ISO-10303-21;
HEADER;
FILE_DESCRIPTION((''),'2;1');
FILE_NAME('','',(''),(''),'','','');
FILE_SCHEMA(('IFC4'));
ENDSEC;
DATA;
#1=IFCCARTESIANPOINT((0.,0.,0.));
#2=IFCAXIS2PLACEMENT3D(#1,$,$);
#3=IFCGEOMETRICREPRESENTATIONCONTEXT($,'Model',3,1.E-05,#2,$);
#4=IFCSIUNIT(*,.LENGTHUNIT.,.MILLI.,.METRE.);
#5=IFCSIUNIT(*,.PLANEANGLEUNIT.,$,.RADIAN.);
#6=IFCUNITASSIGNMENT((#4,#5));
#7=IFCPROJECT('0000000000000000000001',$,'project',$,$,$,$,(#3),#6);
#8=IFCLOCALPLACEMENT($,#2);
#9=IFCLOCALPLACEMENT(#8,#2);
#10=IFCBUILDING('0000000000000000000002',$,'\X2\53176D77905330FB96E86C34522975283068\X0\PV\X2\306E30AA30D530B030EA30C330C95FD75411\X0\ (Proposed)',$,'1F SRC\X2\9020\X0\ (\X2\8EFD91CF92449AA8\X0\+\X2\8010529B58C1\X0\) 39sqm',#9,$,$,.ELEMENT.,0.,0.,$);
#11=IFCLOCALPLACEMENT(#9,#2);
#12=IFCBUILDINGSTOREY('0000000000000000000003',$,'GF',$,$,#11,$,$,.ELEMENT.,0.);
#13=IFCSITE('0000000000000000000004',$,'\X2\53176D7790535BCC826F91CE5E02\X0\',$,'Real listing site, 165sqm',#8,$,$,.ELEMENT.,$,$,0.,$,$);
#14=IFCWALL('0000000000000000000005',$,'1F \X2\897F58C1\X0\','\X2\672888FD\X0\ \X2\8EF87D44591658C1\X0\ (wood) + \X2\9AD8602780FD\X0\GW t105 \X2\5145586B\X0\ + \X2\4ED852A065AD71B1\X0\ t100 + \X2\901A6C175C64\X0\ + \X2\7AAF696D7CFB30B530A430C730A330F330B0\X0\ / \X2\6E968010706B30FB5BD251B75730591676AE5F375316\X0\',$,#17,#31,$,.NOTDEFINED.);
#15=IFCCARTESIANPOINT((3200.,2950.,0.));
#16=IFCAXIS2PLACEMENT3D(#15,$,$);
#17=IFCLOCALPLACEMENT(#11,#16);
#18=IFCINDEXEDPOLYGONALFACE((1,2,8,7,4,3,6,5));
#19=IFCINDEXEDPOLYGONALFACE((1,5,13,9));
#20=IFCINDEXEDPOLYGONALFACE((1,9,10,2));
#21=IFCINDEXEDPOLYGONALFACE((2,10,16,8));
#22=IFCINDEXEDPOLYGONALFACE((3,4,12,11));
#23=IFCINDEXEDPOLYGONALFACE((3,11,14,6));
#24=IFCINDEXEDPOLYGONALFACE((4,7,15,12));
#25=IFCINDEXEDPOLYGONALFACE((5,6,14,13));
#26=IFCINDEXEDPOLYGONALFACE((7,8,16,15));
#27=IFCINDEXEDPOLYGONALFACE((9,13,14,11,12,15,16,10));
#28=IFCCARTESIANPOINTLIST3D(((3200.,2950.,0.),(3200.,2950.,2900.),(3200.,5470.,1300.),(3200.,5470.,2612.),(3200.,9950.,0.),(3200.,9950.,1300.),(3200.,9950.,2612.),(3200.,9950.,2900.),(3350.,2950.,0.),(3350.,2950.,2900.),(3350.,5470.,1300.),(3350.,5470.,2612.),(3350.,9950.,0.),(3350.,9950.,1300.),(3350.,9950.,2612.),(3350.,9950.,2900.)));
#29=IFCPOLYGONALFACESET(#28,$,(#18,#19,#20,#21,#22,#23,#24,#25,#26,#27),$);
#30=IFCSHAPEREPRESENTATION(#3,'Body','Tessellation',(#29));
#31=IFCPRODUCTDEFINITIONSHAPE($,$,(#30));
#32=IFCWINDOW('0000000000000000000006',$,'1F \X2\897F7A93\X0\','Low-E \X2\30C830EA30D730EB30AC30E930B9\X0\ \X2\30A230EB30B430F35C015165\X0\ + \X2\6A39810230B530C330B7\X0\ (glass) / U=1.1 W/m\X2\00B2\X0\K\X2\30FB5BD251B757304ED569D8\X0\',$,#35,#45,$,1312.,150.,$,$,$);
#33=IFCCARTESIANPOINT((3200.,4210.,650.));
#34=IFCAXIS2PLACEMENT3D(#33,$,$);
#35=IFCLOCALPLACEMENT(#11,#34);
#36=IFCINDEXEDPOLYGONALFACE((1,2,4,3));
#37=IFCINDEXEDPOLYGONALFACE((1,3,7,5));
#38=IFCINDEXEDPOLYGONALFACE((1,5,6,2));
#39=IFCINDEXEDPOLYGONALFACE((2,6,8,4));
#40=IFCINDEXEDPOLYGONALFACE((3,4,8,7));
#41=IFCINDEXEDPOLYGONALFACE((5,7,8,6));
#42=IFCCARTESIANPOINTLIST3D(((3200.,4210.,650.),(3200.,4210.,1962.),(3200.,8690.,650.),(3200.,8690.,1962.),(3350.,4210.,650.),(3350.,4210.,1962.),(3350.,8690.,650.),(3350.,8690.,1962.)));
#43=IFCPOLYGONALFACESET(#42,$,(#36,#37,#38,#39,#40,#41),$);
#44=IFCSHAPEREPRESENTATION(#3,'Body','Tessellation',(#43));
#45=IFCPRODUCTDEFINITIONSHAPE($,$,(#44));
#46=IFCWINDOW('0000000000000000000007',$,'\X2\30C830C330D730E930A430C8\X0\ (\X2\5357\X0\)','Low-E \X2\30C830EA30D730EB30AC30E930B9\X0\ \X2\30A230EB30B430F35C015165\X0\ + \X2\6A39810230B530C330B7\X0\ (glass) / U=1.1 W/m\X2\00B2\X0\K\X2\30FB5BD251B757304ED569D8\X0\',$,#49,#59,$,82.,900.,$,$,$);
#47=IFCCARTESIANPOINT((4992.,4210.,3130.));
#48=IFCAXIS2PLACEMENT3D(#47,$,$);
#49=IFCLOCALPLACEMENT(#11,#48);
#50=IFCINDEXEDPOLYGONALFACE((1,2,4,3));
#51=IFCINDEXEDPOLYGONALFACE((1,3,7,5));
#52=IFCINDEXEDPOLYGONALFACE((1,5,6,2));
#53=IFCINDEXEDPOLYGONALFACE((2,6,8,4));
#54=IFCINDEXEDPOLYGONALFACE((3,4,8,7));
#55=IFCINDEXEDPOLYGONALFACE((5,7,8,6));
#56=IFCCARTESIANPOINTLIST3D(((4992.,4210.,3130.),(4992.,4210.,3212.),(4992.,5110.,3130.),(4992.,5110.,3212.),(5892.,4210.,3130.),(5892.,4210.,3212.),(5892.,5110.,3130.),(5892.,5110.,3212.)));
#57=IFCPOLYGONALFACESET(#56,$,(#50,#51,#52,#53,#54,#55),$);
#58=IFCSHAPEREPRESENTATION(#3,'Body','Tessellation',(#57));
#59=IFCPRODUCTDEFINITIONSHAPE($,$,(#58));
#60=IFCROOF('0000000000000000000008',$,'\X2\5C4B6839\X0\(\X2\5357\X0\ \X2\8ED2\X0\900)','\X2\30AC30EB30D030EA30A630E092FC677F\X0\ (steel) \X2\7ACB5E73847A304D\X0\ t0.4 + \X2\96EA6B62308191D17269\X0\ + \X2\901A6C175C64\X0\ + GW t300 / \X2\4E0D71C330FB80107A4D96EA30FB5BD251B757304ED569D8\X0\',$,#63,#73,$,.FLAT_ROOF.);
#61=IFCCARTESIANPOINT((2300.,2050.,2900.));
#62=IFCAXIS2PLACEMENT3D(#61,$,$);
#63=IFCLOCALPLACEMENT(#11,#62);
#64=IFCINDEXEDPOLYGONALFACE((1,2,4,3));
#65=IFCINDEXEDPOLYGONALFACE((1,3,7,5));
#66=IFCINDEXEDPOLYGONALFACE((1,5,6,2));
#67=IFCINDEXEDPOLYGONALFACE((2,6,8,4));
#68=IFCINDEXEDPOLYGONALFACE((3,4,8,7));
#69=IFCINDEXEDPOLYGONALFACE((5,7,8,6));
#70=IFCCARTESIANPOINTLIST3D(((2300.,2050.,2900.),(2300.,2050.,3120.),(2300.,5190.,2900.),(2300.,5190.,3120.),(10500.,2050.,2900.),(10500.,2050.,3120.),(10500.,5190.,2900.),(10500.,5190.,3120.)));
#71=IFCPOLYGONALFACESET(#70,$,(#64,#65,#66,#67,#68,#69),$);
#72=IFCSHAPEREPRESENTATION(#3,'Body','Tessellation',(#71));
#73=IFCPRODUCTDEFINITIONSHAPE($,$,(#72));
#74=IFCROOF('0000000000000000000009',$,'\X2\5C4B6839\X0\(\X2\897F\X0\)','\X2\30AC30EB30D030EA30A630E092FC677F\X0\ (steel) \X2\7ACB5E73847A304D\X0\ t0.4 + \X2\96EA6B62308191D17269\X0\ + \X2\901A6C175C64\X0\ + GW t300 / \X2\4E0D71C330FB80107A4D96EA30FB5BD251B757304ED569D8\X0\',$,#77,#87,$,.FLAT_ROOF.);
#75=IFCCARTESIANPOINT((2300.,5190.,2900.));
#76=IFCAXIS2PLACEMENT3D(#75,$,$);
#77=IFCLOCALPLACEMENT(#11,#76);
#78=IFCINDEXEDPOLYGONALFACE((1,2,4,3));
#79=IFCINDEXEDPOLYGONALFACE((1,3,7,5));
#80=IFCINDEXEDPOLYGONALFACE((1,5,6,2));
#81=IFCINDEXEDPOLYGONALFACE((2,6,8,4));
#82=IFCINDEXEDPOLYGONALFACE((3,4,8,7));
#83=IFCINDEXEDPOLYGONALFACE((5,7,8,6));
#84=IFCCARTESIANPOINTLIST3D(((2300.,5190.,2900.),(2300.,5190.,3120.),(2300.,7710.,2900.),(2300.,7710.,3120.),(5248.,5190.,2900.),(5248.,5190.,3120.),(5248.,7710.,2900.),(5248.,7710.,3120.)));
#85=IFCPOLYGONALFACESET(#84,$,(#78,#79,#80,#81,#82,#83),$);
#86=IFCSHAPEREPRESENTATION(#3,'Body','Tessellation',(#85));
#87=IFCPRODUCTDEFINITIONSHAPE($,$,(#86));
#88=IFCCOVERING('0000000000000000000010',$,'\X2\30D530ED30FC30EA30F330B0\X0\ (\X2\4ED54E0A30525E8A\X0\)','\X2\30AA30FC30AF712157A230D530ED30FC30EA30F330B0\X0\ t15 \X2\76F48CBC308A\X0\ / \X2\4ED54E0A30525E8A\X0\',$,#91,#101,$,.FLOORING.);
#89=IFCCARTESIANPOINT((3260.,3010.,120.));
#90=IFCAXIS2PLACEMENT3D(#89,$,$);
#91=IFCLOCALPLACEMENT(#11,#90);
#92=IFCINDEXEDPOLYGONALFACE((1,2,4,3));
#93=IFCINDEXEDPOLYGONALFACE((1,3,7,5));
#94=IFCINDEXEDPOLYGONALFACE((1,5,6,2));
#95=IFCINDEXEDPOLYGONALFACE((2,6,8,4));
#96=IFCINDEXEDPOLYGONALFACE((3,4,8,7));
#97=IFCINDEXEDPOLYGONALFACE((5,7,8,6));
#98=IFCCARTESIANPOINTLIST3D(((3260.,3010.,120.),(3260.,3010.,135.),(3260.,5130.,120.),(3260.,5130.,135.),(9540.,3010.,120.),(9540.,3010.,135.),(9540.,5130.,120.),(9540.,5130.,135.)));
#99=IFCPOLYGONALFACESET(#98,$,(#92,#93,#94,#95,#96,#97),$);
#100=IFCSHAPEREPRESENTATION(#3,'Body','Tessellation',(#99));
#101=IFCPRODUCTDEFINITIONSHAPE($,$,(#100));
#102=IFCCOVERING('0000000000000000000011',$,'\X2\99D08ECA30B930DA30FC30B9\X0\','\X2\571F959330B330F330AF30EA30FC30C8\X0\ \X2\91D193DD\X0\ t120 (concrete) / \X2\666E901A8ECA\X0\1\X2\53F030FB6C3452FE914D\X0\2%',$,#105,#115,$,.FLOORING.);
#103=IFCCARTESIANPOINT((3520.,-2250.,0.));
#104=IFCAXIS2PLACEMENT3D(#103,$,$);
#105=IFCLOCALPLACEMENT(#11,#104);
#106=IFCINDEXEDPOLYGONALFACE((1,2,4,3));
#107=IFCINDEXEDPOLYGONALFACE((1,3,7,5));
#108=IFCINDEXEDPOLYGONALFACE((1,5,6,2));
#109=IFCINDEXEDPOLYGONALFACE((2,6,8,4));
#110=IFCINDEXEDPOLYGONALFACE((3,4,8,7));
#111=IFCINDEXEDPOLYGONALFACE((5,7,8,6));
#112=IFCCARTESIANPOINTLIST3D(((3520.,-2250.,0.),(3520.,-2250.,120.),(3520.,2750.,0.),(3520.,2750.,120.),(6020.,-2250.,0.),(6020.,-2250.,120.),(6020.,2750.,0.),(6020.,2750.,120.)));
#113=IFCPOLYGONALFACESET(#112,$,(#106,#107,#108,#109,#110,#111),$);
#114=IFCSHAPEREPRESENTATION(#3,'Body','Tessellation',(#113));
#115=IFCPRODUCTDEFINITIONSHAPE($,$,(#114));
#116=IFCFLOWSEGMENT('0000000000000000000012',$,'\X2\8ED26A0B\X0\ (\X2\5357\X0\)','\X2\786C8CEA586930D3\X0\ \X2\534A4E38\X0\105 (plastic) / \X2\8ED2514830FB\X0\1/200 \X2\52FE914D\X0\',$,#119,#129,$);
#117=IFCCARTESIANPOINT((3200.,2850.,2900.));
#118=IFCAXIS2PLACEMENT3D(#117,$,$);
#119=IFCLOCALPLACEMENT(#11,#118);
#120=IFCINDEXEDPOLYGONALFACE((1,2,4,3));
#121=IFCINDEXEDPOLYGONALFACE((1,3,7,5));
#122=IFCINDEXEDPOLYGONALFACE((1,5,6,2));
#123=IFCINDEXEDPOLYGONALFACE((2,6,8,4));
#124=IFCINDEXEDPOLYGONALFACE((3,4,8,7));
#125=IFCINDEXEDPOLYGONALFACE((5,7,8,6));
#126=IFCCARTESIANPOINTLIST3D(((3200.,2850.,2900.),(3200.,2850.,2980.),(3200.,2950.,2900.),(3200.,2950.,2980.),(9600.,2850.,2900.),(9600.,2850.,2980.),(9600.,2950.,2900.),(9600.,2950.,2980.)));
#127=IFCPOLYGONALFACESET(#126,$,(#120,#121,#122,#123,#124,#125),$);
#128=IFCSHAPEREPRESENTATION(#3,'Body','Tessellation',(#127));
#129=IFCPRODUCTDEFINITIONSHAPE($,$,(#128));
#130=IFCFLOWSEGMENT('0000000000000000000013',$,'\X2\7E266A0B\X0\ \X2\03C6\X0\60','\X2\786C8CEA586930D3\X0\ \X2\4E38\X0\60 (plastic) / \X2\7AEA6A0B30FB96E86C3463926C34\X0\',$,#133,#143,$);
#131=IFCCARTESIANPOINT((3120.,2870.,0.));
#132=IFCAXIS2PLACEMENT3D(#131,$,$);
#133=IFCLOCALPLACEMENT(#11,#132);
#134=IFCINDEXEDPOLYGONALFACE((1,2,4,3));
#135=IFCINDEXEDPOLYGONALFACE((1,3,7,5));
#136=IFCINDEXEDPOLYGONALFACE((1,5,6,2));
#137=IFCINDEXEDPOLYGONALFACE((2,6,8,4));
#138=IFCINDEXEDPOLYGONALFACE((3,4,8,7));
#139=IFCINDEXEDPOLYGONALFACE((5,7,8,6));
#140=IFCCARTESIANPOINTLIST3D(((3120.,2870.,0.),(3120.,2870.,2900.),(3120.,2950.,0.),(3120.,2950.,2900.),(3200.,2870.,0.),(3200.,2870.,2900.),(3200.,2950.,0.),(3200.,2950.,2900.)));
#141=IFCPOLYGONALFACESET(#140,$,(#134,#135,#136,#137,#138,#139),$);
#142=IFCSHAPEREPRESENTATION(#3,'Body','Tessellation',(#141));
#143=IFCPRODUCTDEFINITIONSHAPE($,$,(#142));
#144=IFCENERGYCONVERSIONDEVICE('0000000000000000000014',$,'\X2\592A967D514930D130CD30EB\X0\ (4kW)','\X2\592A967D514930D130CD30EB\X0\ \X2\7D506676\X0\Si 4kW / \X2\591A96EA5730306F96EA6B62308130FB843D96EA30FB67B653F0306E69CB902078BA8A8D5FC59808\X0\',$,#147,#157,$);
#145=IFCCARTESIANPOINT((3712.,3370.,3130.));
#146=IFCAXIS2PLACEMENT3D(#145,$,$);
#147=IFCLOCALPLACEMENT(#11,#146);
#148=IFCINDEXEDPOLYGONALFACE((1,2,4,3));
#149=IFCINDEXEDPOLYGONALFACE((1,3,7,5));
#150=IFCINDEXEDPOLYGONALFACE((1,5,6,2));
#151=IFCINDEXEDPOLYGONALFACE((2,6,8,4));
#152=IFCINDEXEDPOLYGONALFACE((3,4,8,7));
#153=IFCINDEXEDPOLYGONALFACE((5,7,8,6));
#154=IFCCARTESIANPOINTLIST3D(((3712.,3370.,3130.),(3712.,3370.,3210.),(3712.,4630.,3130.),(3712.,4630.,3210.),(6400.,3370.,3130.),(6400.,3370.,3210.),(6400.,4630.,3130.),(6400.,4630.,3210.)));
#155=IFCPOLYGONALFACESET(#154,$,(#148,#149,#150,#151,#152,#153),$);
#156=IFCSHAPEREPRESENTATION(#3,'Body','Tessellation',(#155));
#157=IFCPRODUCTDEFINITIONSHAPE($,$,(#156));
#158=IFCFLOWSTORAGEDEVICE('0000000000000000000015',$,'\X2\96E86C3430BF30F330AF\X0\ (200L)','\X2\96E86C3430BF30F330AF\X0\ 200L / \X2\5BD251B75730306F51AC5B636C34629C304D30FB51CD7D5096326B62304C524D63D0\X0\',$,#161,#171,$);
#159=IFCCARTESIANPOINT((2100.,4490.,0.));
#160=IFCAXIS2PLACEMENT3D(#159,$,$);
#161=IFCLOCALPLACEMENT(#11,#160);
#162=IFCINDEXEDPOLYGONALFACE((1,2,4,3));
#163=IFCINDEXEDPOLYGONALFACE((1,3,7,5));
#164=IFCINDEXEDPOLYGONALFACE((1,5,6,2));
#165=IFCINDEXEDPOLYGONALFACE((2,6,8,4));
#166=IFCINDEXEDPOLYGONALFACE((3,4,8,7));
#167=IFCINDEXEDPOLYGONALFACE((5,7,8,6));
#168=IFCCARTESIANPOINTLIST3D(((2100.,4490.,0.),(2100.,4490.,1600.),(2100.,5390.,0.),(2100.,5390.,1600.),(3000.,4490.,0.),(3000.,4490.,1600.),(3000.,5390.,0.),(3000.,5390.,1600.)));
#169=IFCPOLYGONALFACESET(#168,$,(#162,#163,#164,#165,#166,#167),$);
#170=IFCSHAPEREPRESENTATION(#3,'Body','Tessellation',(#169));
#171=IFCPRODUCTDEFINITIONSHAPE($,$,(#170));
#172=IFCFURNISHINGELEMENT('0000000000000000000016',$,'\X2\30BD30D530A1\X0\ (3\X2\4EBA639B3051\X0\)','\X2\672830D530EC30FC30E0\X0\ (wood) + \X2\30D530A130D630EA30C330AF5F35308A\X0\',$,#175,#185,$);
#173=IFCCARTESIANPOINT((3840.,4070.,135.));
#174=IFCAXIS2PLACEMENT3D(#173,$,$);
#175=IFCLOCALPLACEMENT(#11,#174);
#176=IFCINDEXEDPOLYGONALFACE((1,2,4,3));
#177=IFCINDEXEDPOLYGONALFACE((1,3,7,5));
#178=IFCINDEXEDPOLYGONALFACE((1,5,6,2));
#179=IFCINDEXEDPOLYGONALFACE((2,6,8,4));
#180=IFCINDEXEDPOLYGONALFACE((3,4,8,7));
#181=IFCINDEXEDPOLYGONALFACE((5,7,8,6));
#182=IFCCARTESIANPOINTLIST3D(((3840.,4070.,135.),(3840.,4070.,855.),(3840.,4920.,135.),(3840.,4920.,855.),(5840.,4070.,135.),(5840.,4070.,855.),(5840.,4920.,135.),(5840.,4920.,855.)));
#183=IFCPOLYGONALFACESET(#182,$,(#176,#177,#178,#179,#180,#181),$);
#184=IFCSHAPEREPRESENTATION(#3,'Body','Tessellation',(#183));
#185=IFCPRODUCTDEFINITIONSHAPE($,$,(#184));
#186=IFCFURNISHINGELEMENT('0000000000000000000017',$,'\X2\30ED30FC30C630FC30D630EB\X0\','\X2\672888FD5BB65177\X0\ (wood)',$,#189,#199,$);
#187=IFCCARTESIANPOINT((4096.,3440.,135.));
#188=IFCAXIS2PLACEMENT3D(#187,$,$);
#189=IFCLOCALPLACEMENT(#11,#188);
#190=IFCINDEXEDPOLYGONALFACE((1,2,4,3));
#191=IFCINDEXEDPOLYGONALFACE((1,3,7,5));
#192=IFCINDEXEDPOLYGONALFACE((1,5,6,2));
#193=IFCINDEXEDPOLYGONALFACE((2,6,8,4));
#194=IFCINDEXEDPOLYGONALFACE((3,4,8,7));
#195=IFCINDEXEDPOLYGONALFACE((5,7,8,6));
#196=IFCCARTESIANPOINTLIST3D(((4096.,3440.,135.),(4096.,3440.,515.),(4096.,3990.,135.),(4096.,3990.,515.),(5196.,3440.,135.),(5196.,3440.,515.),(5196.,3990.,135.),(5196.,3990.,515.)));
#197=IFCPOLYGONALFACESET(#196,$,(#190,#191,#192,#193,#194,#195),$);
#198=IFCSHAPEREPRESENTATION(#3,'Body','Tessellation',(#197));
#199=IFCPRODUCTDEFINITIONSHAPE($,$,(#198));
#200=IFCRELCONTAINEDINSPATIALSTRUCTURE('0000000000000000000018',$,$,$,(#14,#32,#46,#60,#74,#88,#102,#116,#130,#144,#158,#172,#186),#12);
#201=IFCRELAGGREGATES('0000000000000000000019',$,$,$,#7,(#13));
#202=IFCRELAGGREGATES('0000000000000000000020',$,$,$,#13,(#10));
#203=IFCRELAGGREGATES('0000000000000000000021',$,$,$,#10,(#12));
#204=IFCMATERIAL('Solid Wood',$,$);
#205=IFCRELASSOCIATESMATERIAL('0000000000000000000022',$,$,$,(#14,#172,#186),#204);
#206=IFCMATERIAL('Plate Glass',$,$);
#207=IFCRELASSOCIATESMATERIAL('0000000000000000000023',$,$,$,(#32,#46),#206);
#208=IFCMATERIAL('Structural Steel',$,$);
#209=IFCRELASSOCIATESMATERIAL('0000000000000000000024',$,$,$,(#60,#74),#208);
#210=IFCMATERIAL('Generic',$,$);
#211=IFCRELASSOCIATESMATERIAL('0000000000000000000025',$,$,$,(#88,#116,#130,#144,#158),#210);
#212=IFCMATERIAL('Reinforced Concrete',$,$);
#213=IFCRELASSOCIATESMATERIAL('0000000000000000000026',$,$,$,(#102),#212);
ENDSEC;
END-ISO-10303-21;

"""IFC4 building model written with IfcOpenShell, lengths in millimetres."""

from ifc_helpers import new_model, si_unit, frame, frame_2d, origin, place, context, project, spatial, rectangle, extrude, material, element, fill, save


model = new_model("IFC4")

# Units and contexts
model_context = context("Model", 3, precision=1e-05, world=origin())
ifc_project = project(units=[si_unit("LENGTHUNIT", "METRE", prefix="MILLI"), si_unit("PLANEANGLEUNIT", "RADIAN")], contexts=[model_context])

# Site, building, storey
site_placement = place(None, origin())
site = spatial("IfcSite", under=ifc_project, at=site_placement, Name="北海道富良野市", ObjectType="Real listing site, 165sqm", CompositionType="ELEMENT", RefElevation=0.0)
building_placement = place(site_placement, origin())
building = spatial("IfcBuilding", under=site, at=building_placement, Name="北海道・雨水利用とPVのオフグリッド志向 (Proposed)", ObjectType="1F SRC造 (軽量鉄骨+耐力壁) 39sqm", CompositionType="ELEMENT", ElevationOfRefHeight=0.0, ElevationOfTerrain=0.0)
storey_placement = place(building_placement, origin())
storey = spatial("IfcBuildingStorey", under=building, at=storey_placement, Name="GF", CompositionType="ELEMENT", Elevation=0.0)

# Shared definitions
ifc_material_1 = material(Name="Solid Wood")

# Shared definitions
ifc_material_2 = material(Name="Reinforced Concrete")

# Shared definitions
ifc_material_3 = material(Name="Plate Glass")

# Wall, opening, window
wall_1_placement = place(storey_placement, frame((3200.0, 2950.0, 0.0)))
wall_1 = element("IfcWall", 1, at=wall_1_placement, inside=storey, material=ifc_material_1, Name="1F 西壁", Description="木製 軸組外壁 (wood) + 高性能GW t105 充填 + 付加断熱 t100 + 通気層 + 窯業系サイディング / 準耐火・寒冷地外皮強化", PredefinedType="NOTDEFINED", context=model_context, shape_type="SweptSolid", body=[
    extrude(rectangle(XDim=150.0, YDim=7000.0, at=frame_2d((75.0, 3500.0))), frame((3200.0, 2950.0, 0.0)), (0.0, 0.0, 1.0), 2900.0),
])
opening_1_placement = place(storey_placement, frame((3200.0, 4210.0, 650.0)))
opening_1 = element("IfcOpeningElement", 2, at=opening_1_placement, cuts=wall_1, PredefinedType="NOTDEFINED", context=model_context, shape_type="SweptSolid", body=[
    extrude(rectangle(XDim=150.0, YDim=4480.0, at=frame_2d((75.0, 2240.0))), frame((3200.0, 4210.0, 650.0)), (0.0, 0.0, 1.0), 1312.0),
])
window_1_placement = place(storey_placement, frame((3200.0, 4210.0, 650.0)))
window_1 = element("IfcWindow", 3, at=window_1_placement, inside=storey, material=ifc_material_3, Name="1F 西窓", Description="Low-E トリプルガラス アルゴン封入 + 樹脂サッシ (glass) / U=1.1 W/m²K・寒冷地仕様", OverallHeight=1312.0, OverallWidth=150.0, context=model_context, shape_type="SweptSolid", body=[
    extrude(rectangle(XDim=150.0, YDim=4480.0, at=frame_2d((75.0, 2240.0))), frame((3200.0, 4210.0, 650.0)), (0.0, 0.0, 1.0), 1312.0),
])
fill(opening_1, window_1)

# Window
window_2_placement = place(storey_placement, frame((4992.0, 4210.0, 3130.0)))
element("IfcWindow", 4, at=window_2_placement, inside=storey, material=ifc_material_3, Name="トップライト (南)", Description="Low-E トリプルガラス アルゴン封入 + 樹脂サッシ (glass) / U=1.1 W/m²K・寒冷地仕様", OverallHeight=82.0, OverallWidth=900.0, context=model_context, shape_type="SweptSolid", body=[
    extrude(rectangle(XDim=900.0, YDim=900.0, at=frame_2d((450.0, 450.0))), frame((4992.0, 4210.0, 3130.0)), (0.0, 0.0, 1.0), 82.0),
])

# Roofs
ifc_material_4 = material(Name="Structural Steel")
roof_1_placement = place(storey_placement, frame((2300.0, 2050.0, 2900.0)))
element("IfcRoof", 5, at=roof_1_placement, inside=storey, material=ifc_material_4, Name="屋根(南 軒900)", Description="ガルバリウム鋼板 (steel) 立平葺き t0.4 + 雪止め金物 + 通気層 + GW t300 / 不燃・耐積雪・寒冷地仕様", PredefinedType="FLAT_ROOF", context=model_context, shape_type="SweptSolid", body=[
    extrude(rectangle(XDim=8200.0, YDim=3140.0, at=frame_2d((4100.0, 1570.0))), frame((2300.0, 2050.0, 2900.0)), (0.0, 0.0, 1.0), 220.0),
])
roof_2_placement = place(storey_placement, frame((2300.0, 5190.0, 2900.0)))
element("IfcRoof", 6, at=roof_2_placement, inside=storey, material=ifc_material_4, Name="屋根(西)", Description="ガルバリウム鋼板 (steel) 立平葺き t0.4 + 雪止め金物 + 通気層 + GW t300 / 不燃・耐積雪・寒冷地仕様", PredefinedType="FLAT_ROOF", context=model_context, shape_type="SweptSolid", body=[
    extrude(rectangle(XDim=2948.0, YDim=2520.0, at=frame_2d((1474.0, 1260.0))), frame((2300.0, 5190.0, 2900.0)), (0.0, 0.0, 1.0), 220.0),
])

# Coverings
ifc_material_5 = material(Name="Generic")
covering_1_placement = place(storey_placement, frame((3260.0, 3010.0, 120.0)))
element("IfcCovering", 7, at=covering_1_placement, inside=storey, material=ifc_material_5, Name="フローリング (仕上げ床)", Description="オーク無垢フローリング t15 直貼り / 仕上げ床", PredefinedType="FLOORING", context=model_context, shape_type="SweptSolid", body=[
    extrude(rectangle(XDim=6280.0, YDim=2120.0, at=frame_2d((3140.0, 1060.0))), frame((3260.0, 3010.0, 120.0)), (0.0, 0.0, 1.0), 15.0),
])
covering_2_placement = place(storey_placement, frame((3520.0, -2250.0, 0.0)))
element("IfcCovering", 8, at=covering_2_placement, inside=storey, material=ifc_material_2, Name="駐車スペース", Description="土間コンクリート 金鏝 t120 (concrete) / 普通車1台・水勾配2%", PredefinedType="FLOORING", context=model_context, shape_type="SweptSolid", body=[
    extrude(rectangle(XDim=2500.0, YDim=5000.0, at=frame_2d((1250.0, 2500.0))), frame((3520.0, -2250.0, 0.0)), (0.0, 0.0, 1.0), 120.0),
])

# Flow segments
flow_segment_1_placement = place(storey_placement, frame((3200.0, 2850.0, 2900.0)))
element("IfcFlowSegment", 9, at=flow_segment_1_placement, inside=storey, material=ifc_material_5, Name="軒樋 (南)", Description="硬質塩ビ 半丸105 (plastic) / 軒先・1/200 勾配", context=model_context, shape_type="SweptSolid", body=[
    extrude(rectangle(XDim=6400.0, YDim=100.0, at=frame_2d((3200.0, 50.0))), frame((3200.0, 2850.0, 2900.0)), (0.0, 0.0, 1.0), 80.0),
])
flow_segment_2_placement = place(storey_placement, frame((3120.0, 2870.0, 0.0)))
element("IfcFlowSegment", 10, at=flow_segment_2_placement, inside=storey, material=ifc_material_5, Name="縦樋 φ60", Description="硬質塩ビ 丸60 (plastic) / 竪樋・雨水排水", context=model_context, shape_type="SweptSolid", body=[
    extrude(rectangle(XDim=80.0, YDim=80.0, at=frame_2d((40.0, 40.0))), frame((3120.0, 2870.0, 0.0)), (0.0, 0.0, 1.0), 2900.0),
])

# Energy conversion device
energy_conversion_device_placement = place(storey_placement, frame((3712.0, 3370.0, 3130.0)))
element("IfcEnergyConversionDevice", 11, at=energy_conversion_device_placement, inside=storey, material=ifc_material_5, Name="太陽光パネル (4kW)", Description="太陽光パネル 結晶Si 4kW / 多雪地は雪止め・落雪・架台の構造確認必須", context=model_context, shape_type="SweptSolid", body=[
    extrude(rectangle(XDim=2688.0, YDim=1260.0, at=frame_2d((1344.0, 630.0))), frame((3712.0, 3370.0, 3130.0)), (0.0, 0.0, 1.0), 80.0),
])

# Flow storage device
flow_storage_device_placement = place(storey_placement, frame((2100.0, 4490.0, 0.0)))
element("IfcFlowStorageDevice", 12, at=flow_storage_device_placement, inside=storey, material=ifc_material_5, Name="雨水タンク (200L)", Description="雨水タンク 200L / 寒冷地は冬季水抜き・凍結防止が前提", context=model_context, shape_type="SweptSolid", body=[
    extrude(rectangle(XDim=900.0, YDim=900.0, at=frame_2d((450.0, 450.0))), frame((2100.0, 4490.0, 0.0)), (0.0, 0.0, 1.0), 1600.0),
])

# Furnishing elements
furnishing_1_placement = place(storey_placement, frame((3840.0, 4070.0, 135.0)))
element("IfcFurnishingElement", 13, at=furnishing_1_placement, inside=storey, material=ifc_material_1, Name="ソファ (3人掛け)", Description="木フレーム (wood) + ファブリック張り", context=model_context, shape_type="SweptSolid", body=[
    extrude(rectangle(XDim=2000.0, YDim=850.0, at=frame_2d((1000.0, 425.0))), frame((3840.0, 4070.0, 135.0)), (0.0, 0.0, 1.0), 720.0),
])
furnishing_2_placement = place(storey_placement, frame((4096.0, 3440.0, 135.0)))
element("IfcFurnishingElement", 14, at=furnishing_2_placement, inside=storey, material=ifc_material_1, Name="ローテーブル", Description="木製家具 (wood)", context=model_context, shape_type="SweptSolid", body=[
    extrude(rectangle(XDim=1100.0, YDim=550.0, at=frame_2d((550.0, 275.0))), frame((4096.0, 3440.0, 135.0)), (0.0, 0.0, 1.0), 380.0),
])

save(model, "model.ifc")
